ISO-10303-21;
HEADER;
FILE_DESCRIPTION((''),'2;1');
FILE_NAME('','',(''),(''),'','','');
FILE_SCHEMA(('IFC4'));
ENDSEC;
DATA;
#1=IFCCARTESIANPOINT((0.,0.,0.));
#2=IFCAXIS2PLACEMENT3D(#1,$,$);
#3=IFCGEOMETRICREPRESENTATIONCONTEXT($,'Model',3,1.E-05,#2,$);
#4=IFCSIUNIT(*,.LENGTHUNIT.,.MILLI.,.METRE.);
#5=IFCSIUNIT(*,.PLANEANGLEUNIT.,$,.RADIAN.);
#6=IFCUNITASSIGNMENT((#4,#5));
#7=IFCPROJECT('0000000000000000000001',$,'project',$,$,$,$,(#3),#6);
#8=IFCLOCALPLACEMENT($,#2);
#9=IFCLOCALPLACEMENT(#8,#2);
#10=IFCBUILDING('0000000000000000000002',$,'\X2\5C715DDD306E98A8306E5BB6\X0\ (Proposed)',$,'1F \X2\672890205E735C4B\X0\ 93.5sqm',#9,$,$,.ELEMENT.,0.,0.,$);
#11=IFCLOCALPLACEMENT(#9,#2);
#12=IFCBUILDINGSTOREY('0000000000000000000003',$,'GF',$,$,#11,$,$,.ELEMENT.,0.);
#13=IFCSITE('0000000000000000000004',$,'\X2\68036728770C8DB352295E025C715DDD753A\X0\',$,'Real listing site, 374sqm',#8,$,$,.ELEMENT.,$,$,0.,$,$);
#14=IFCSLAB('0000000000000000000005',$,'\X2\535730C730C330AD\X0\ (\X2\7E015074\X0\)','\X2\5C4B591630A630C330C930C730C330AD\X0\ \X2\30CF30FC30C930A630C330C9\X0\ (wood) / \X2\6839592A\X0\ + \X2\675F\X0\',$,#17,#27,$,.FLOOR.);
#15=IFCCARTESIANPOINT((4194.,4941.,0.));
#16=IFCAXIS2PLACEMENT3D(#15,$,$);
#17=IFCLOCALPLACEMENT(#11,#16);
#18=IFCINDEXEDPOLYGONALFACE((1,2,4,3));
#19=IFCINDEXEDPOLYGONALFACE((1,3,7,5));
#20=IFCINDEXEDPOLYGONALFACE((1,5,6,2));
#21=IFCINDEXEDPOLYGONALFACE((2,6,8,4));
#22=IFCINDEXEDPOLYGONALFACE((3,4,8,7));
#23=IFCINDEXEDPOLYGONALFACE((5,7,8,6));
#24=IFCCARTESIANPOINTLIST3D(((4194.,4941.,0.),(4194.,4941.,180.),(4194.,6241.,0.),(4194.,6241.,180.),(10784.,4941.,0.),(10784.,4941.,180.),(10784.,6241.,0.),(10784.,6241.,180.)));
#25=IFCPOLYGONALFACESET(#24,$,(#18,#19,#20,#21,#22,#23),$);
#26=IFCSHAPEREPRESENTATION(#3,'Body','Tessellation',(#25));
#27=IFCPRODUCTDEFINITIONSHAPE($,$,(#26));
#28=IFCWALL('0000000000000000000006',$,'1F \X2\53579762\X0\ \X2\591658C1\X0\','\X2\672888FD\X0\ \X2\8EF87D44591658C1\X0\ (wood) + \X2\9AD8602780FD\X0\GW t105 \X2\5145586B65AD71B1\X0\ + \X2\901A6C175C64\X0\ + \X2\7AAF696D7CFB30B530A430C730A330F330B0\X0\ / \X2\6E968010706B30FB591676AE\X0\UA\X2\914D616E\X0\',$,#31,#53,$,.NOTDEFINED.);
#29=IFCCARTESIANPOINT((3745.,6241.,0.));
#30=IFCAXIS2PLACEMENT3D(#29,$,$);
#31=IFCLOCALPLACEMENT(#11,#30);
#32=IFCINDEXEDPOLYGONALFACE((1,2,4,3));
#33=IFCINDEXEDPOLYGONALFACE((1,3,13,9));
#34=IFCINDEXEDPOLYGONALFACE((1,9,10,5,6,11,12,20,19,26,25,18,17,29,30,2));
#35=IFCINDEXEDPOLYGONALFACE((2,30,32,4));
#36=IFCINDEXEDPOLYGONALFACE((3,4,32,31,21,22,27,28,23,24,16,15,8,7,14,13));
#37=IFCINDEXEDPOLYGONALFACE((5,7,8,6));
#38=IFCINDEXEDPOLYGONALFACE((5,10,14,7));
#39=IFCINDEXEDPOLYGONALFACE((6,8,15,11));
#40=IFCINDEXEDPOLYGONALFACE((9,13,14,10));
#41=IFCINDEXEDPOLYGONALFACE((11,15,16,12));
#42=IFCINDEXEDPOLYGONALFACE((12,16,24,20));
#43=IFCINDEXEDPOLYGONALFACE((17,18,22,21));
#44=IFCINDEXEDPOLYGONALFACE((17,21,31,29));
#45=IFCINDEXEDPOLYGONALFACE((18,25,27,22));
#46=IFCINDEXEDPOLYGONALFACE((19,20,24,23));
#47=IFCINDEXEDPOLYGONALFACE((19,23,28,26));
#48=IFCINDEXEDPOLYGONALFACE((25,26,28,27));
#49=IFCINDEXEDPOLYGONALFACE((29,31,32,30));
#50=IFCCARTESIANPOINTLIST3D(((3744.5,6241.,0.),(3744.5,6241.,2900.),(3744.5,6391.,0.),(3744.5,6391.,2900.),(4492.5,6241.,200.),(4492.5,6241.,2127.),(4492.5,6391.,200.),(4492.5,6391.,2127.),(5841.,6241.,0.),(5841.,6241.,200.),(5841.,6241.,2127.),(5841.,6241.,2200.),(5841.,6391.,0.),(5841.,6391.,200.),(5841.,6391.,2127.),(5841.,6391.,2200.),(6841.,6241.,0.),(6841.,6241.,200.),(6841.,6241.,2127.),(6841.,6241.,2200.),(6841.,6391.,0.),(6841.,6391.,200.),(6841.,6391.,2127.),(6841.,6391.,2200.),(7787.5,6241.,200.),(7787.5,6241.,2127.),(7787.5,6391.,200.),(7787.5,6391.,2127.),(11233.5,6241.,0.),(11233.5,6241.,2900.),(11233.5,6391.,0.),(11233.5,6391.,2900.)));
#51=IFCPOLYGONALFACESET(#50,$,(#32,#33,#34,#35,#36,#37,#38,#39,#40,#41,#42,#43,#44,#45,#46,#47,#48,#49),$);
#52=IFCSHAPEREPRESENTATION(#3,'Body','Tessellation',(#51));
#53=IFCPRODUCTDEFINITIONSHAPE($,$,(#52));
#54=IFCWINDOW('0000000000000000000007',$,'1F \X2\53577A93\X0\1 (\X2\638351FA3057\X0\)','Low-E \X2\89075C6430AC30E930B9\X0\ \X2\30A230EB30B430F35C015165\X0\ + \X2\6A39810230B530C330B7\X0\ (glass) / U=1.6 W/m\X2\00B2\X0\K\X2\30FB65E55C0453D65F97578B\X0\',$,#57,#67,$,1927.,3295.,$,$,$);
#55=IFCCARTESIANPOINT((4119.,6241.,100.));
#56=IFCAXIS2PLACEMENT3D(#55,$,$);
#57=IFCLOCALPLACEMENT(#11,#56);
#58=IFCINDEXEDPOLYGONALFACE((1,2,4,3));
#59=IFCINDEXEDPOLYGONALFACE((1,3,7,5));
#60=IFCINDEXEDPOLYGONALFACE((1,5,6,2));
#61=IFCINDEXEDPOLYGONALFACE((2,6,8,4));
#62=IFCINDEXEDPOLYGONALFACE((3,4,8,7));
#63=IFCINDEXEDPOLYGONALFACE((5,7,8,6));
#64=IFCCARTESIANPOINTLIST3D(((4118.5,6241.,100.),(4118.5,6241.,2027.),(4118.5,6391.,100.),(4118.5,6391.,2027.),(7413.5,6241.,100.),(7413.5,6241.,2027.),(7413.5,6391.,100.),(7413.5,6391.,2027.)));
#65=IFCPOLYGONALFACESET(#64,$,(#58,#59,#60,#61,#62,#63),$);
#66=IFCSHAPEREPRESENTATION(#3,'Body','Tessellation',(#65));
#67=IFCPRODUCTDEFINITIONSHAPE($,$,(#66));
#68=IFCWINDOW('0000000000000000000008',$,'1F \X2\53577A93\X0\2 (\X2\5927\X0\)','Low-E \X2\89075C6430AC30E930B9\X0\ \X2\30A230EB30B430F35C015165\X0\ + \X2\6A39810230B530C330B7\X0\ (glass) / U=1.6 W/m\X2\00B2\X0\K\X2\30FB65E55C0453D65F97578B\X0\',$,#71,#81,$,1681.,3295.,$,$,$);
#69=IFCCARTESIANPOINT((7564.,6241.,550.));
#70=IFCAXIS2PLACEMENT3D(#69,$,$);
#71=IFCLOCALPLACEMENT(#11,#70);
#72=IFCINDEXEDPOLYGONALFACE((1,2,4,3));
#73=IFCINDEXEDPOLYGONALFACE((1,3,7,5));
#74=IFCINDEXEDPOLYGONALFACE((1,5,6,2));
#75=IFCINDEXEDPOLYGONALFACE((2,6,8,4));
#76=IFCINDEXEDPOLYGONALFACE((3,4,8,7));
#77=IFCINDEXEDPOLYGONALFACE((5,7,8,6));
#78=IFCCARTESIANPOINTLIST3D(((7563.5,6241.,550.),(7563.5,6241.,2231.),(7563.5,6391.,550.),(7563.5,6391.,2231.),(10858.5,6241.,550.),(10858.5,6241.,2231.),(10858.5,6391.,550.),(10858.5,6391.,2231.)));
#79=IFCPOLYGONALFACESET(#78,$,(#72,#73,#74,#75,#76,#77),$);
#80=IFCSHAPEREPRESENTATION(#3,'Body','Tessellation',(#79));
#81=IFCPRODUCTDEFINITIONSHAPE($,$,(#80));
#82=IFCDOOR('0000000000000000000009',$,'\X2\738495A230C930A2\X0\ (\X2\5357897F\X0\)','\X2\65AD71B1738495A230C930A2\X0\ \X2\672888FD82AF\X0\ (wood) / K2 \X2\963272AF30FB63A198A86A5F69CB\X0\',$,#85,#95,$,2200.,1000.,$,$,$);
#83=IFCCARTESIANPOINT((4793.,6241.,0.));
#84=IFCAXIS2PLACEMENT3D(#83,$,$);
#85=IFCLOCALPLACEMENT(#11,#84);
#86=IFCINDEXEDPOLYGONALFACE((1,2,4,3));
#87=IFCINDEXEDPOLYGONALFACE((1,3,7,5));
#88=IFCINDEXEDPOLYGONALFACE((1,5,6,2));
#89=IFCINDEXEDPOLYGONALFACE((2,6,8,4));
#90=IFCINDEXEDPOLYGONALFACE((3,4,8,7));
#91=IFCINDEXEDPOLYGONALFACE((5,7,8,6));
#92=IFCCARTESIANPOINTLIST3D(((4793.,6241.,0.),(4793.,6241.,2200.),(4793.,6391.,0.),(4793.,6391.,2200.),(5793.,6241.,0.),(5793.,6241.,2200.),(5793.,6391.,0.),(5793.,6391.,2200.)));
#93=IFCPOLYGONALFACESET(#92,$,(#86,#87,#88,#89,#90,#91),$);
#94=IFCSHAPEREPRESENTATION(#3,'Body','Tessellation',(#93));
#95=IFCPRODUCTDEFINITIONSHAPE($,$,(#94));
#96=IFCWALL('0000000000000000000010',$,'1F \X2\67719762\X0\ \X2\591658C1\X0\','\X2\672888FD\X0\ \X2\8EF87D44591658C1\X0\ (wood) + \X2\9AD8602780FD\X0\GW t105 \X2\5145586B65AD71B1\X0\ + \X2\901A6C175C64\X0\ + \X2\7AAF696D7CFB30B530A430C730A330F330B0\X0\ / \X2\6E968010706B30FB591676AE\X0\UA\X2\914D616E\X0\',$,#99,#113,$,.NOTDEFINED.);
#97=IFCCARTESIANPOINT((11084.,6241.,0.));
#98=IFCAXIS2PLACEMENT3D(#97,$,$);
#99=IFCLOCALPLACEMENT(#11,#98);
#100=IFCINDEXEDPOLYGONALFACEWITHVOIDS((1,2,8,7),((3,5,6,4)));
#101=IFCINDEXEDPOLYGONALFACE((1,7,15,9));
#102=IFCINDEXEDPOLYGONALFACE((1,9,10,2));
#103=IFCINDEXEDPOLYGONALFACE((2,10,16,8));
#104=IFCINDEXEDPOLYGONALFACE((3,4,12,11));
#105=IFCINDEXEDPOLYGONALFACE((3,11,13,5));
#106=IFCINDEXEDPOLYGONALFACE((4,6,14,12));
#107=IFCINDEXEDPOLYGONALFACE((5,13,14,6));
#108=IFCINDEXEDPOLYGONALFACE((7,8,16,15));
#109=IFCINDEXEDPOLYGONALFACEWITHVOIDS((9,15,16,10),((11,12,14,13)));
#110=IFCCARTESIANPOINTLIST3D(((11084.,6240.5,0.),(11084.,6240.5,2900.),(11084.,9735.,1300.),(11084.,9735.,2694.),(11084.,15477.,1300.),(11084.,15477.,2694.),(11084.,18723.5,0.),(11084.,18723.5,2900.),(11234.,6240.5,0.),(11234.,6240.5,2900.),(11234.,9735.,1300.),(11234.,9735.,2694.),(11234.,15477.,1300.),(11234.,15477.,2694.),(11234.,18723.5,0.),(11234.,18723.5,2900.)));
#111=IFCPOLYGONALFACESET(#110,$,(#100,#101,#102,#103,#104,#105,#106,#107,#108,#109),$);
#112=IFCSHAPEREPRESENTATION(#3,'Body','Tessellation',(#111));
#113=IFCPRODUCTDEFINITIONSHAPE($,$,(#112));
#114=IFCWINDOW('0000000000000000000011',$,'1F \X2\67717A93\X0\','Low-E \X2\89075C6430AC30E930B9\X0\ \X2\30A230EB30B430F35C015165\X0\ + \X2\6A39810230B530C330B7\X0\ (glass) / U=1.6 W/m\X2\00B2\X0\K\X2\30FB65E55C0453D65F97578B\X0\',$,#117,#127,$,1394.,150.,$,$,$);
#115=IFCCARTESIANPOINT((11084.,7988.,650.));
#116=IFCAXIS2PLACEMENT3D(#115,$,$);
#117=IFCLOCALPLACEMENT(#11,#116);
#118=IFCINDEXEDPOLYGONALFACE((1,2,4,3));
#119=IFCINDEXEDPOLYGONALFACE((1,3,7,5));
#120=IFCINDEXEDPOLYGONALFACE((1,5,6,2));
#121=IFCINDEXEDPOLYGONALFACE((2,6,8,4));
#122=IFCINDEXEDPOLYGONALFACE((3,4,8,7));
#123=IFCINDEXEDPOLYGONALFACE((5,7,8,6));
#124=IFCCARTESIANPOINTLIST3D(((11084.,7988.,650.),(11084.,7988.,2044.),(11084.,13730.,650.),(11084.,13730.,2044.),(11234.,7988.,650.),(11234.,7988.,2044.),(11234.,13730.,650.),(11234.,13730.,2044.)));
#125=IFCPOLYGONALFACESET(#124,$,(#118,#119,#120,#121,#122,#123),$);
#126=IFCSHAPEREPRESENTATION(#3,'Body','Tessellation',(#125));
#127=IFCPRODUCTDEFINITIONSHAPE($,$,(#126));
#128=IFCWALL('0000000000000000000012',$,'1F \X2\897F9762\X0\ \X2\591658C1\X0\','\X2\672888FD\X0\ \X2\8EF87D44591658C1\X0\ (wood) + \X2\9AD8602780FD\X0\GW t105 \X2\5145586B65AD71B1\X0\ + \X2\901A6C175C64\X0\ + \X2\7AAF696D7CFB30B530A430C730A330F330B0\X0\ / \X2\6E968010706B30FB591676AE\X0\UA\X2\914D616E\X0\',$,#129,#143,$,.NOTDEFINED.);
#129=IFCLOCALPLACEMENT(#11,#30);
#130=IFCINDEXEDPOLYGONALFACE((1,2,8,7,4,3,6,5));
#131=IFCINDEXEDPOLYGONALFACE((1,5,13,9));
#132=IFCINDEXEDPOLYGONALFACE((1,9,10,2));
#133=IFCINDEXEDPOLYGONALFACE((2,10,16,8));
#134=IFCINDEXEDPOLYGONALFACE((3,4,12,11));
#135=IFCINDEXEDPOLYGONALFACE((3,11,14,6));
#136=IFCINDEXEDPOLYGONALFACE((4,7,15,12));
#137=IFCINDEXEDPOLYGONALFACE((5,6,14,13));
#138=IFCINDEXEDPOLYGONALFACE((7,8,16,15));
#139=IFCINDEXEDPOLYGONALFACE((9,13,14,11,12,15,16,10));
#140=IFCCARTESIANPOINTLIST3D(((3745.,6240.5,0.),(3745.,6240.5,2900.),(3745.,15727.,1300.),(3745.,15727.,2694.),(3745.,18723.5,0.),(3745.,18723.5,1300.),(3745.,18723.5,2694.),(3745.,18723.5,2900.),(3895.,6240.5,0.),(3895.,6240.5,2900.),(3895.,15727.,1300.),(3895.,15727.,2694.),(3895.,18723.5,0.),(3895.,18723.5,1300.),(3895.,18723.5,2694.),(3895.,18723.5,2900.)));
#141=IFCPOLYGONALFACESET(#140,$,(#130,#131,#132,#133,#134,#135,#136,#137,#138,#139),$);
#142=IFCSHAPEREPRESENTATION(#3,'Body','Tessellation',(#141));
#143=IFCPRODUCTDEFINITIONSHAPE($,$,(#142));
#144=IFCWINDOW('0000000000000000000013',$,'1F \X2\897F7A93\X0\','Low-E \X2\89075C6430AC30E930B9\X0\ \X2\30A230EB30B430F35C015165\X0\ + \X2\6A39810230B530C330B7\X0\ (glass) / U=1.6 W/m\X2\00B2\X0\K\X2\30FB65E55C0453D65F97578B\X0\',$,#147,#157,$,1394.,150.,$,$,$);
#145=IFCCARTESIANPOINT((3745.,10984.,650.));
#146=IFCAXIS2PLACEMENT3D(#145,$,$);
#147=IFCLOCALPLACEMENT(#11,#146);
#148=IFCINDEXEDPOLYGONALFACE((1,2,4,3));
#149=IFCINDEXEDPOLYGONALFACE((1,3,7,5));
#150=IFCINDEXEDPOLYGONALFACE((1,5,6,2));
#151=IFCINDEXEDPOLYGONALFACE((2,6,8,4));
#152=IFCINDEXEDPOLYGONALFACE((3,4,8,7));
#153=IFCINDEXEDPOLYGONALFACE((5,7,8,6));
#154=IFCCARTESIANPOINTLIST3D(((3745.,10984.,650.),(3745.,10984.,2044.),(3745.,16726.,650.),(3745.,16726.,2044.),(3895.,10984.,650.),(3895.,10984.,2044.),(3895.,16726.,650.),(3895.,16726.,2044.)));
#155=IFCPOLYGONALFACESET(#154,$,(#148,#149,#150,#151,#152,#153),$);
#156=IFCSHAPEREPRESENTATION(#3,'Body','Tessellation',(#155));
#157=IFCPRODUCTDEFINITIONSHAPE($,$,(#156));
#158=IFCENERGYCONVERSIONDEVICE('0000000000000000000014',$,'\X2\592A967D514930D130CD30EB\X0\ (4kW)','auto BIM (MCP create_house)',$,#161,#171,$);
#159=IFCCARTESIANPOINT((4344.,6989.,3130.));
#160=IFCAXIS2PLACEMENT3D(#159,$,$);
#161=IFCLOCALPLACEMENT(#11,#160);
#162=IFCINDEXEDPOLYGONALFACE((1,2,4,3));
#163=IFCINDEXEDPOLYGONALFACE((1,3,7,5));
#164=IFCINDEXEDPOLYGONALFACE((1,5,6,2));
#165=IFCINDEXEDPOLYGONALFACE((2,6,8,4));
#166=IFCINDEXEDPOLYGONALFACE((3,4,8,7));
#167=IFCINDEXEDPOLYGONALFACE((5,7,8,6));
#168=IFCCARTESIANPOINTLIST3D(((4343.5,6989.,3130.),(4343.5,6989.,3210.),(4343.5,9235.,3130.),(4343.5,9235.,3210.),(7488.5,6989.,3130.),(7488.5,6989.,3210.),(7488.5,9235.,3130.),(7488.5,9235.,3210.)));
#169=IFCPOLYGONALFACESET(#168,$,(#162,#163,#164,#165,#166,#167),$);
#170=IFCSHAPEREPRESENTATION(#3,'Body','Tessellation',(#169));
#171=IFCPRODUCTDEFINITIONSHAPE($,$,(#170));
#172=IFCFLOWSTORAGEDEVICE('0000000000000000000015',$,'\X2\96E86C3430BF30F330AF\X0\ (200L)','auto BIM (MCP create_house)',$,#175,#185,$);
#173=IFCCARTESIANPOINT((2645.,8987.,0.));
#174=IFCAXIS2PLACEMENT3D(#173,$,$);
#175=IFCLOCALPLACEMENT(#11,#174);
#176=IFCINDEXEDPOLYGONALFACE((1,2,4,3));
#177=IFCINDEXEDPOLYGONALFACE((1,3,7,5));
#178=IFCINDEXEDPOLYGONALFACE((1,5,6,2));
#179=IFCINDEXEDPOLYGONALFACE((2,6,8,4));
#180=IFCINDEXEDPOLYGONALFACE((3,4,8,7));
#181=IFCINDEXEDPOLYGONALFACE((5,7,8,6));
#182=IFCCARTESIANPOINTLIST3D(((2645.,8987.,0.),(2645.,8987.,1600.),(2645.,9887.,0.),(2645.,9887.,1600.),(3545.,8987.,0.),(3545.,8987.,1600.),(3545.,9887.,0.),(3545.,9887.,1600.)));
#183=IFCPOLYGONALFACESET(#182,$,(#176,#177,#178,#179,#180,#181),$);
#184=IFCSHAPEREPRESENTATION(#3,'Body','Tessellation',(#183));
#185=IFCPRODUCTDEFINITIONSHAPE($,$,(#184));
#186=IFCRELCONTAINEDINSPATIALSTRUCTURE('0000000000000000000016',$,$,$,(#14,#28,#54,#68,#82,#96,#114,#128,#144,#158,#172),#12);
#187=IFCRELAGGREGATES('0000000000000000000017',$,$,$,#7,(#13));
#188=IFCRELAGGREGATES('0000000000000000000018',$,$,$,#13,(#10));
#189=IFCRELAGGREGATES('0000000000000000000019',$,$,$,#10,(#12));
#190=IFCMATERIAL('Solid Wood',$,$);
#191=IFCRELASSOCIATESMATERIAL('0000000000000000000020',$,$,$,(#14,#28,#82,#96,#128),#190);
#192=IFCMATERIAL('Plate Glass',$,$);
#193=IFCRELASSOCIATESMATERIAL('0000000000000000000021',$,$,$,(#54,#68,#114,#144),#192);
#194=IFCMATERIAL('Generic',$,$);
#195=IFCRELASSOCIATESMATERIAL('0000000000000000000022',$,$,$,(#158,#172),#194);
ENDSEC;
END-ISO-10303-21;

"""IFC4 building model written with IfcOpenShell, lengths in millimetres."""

from ifc_helpers import new_model, si_unit, frame, frame_2d, origin, place, context, project, spatial, rectangle, extrude, material, element, fill, save


model = new_model("IFC4")

# Units and contexts
model_context = context("Model", 3, precision=1e-05, world=origin())
ifc_project = project(units=[si_unit("LENGTHUNIT", "METRE", prefix="MILLI"), si_unit("PLANEANGLEUNIT", "RADIAN")], contexts=[model_context])

# Site, building, storey
site_placement = place(None, origin())
site = spatial("IfcSite", under=ifc_project, at=site_placement, Name="栃木県足利市山川町", ObjectType="Real listing site, 374sqm", CompositionType="ELEMENT", RefElevation=0.0)
building_placement = place(site_placement, origin())
building = spatial("IfcBuilding", under=site, at=building_placement, Name="山川の風の家 (Proposed)", ObjectType="1F 木造平屋 93.5sqm", CompositionType="ELEMENT", ElevationOfRefHeight=0.0, ElevationOfTerrain=0.0)
storey_placement = place(building_placement, origin())
storey = spatial("IfcBuildingStorey", under=building, at=storey_placement, Name="GF", CompositionType="ELEMENT", Elevation=0.0)

# Slab
ifc_material_1 = material(Name="Solid Wood")
slab_1_placement = place(storey_placement, frame((4194.0, 4941.0, 0.0)))
element("IfcSlab", 1, at=slab_1_placement, inside=storey, material=ifc_material_1, Name="南デッキ (縁側)", Description="屋外ウッドデッキ ハードウッド (wood) / 根太 + 束", PredefinedType="FLOOR", context=model_context, shape_type="SweptSolid", body=[
    extrude(rectangle(XDim=6590.0, YDim=1300.0, at=frame_2d((3295.0, 650.0))), frame((4194.0, 4941.0, 0.0)), (0.0, 0.0, 1.0), 180.0),
])

# Wall, openings, windows, door
wall_1_placement = place(storey_placement, frame((3745.0, 6241.0, 0.0)))
wall_1 = element("IfcWall", 2, at=wall_1_placement, inside=storey, material=ifc_material_1, Name="1F 南面 外壁", Description="木製 軸組外壁 (wood) + 高性能GW t105 充填断熱 + 通気層 + 窯業系サイディング / 準耐火・外皮UA配慮", PredefinedType="NOTDEFINED", context=model_context, shape_type="SweptSolid", body=[
    extrude(rectangle(XDim=7489.0, YDim=150.0, at=frame_2d((3744.0, 75.0))), frame((3745.0, 6241.0, 0.0)), (0.0, 0.0, 1.0), 2900.0),
])
opening_1_placement = place(storey_placement, frame((4119.0, 6241.0, 100.0)))
opening_1 = element("IfcOpeningElement", 3, at=opening_1_placement, cuts=wall_1, PredefinedType="NOTDEFINED", context=model_context, shape_type="SweptSolid", body=[
    extrude(rectangle(XDim=3295.0, YDim=150.0, at=frame_2d((1647.0, 75.0))), frame((4119.0, 6241.0, 100.0)), (0.0, 0.0, 1.0), 1927.0),
])
opening_2_placement = place(storey_placement, frame((7564.0, 6241.0, 550.0)))
opening_2 = element("IfcOpeningElement", 4, at=opening_2_placement, cuts=wall_1, PredefinedType="NOTDEFINED", context=model_context, shape_type="SweptSolid", body=[
    extrude(rectangle(XDim=3295.0, YDim=150.0, at=frame_2d((1647.0, 75.0))), frame((7564.0, 6241.0, 550.0)), (0.0, 0.0, 1.0), 1681.0),
])
opening_3_placement = place(storey_placement, frame((4793.0, 6241.0, 0.0)))
opening_3 = element("IfcOpeningElement", 5, at=opening_3_placement, cuts=wall_1, PredefinedType="NOTDEFINED", context=model_context, shape_type="SweptSolid", body=[
    extrude(rectangle(XDim=1000.0, YDim=150.0, at=frame_2d((500.0, 75.0))), frame((4793.0, 6241.0, 0.0)), (0.0, 0.0, 1.0), 2200.0),
])
ifc_material_2 = material(Name="Plate Glass")
window_1_placement = place(storey_placement, frame((4119.0, 6241.0, 100.0)))
window_1 = element("IfcWindow", 6, at=window_1_placement, inside=storey, material=ifc_material_2, Name="1F 南窓1 (掃出し)", Description="Low-E 複層ガラス アルゴン封入 + 樹脂サッシ (glass) / U=1.6 W/m²K・日射取得型", OverallHeight=1927.0, OverallWidth=3295.0, context=model_context, shape_type="SweptSolid", body=[
    extrude(rectangle(XDim=3295.0, YDim=150.0, at=frame_2d((1647.0, 75.0))), frame((4119.0, 6241.0, 100.0)), (0.0, 0.0, 1.0), 1927.0),
])
fill(opening_1, window_1)
window_2_placement = place(storey_placement, frame((7564.0, 6241.0, 550.0)))
window_2 = element("IfcWindow", 7, at=window_2_placement, inside=storey, material=ifc_material_2, Name="1F 南窓2 (大)", Description="Low-E 複層ガラス アルゴン封入 + 樹脂サッシ (glass) / U=1.6 W/m²K・日射取得型", OverallHeight=1681.0, OverallWidth=3295.0, context=model_context, shape_type="SweptSolid", body=[
    extrude(rectangle(XDim=3295.0, YDim=150.0, at=frame_2d((1647.0, 75.0))), frame((7564.0, 6241.0, 550.0)), (0.0, 0.0, 1.0), 1681.0),
])
fill(opening_2, window_2)
door_placement = place(storey_placement, frame((4793.0, 6241.0, 0.0)))
door = element("IfcDoor", 8, at=door_placement, inside=storey, material=ifc_material_1, Name="玄関ドア (南西)", Description="断熱玄関ドア 木製芯 (wood) / K2 防犯・採風機構", OverallHeight=2200.0, OverallWidth=1000.0, context=model_context, shape_type="SweptSolid", body=[
    extrude(rectangle(XDim=1000.0, YDim=150.0, at=frame_2d((500.0, 75.0))), frame((4793.0, 6241.0, 0.0)), (0.0, 0.0, 1.0), 2200.0),
])
fill(opening_3, door)

# Walls, openings, windows
wall_2_placement = place(storey_placement, frame((11084.0, 6241.0, 0.0)))
wall_2 = element("IfcWall", 9, at=wall_2_placement, inside=storey, material=ifc_material_1, Name="1F 東面 外壁", Description="木製 軸組外壁 (wood) + 高性能GW t105 充填断熱 + 通気層 + 窯業系サイディング / 準耐火・外皮UA配慮", PredefinedType="NOTDEFINED", context=model_context, shape_type="SweptSolid", body=[
    extrude(rectangle(XDim=150.0, YDim=12483.0, at=frame_2d((75.0, 6241.0))), frame((11084.0, 6241.0, 0.0)), (0.0, 0.0, 1.0), 2900.0),
])
opening_4_placement = place(storey_placement, frame((11084.0, 7988.0, 650.0)))
opening_4 = element("IfcOpeningElement", 10, at=opening_4_placement, cuts=wall_2, PredefinedType="NOTDEFINED", context=model_context, shape_type="SweptSolid", body=[
    extrude(rectangle(XDim=150.0, YDim=5742.0, at=frame_2d((75.0, 2871.0))), frame((11084.0, 7988.0, 650.0)), (0.0, 0.0, 1.0), 1394.0),
])
window_3_placement = place(storey_placement, frame((11084.0, 7988.0, 650.0)))
window_3 = element("IfcWindow", 11, at=window_3_placement, inside=storey, material=ifc_material_2, Name="1F 東窓", Description="Low-E 複層ガラス アルゴン封入 + 樹脂サッシ (glass) / U=1.6 W/m²K・日射取得型", OverallHeight=1394.0, OverallWidth=150.0, context=model_context, shape_type="SweptSolid", body=[
    extrude(rectangle(XDim=150.0, YDim=5742.0, at=frame_2d((75.0, 2871.0))), frame((11084.0, 7988.0, 650.0)), (0.0, 0.0, 1.0), 1394.0),
])
fill(opening_4, window_3)
wall_3_placement = place(storey_placement, frame((3745.0, 6241.0, 0.0)))
wall_3 = element("IfcWall", 12, at=wall_3_placement, inside=storey, material=ifc_material_1, Name="1F 西面 外壁", Description="木製 軸組外壁 (wood) + 高性能GW t105 充填断熱 + 通気層 + 窯業系サイディング / 準耐火・外皮UA配慮", PredefinedType="NOTDEFINED", context=model_context, shape_type="SweptSolid", body=[
    extrude(rectangle(XDim=150.0, YDim=12483.0, at=frame_2d((75.0, 6241.0))), frame((3745.0, 6241.0, 0.0)), (0.0, 0.0, 1.0), 2900.0),
])
opening_5_placement = place(storey_placement, frame((3745.0, 10984.0, 650.0)))
opening_5 = element("IfcOpeningElement", 13, at=opening_5_placement, cuts=wall_3, PredefinedType="NOTDEFINED", context=model_context, shape_type="SweptSolid", body=[
    extrude(rectangle(XDim=150.0, YDim=5742.0, at=frame_2d((75.0, 2871.0))), frame((3745.0, 10984.0, 650.0)), (0.0, 0.0, 1.0), 1394.0),
])
window_4_placement = place(storey_placement, frame((3745.0, 10984.0, 650.0)))
window_4 = element("IfcWindow", 14, at=window_4_placement, inside=storey, material=ifc_material_2, Name="1F 西窓", Description="Low-E 複層ガラス アルゴン封入 + 樹脂サッシ (glass) / U=1.6 W/m²K・日射取得型", OverallHeight=1394.0, OverallWidth=150.0, context=model_context, shape_type="SweptSolid", body=[
    extrude(rectangle(XDim=150.0, YDim=5742.0, at=frame_2d((75.0, 2871.0))), frame((3745.0, 10984.0, 650.0)), (0.0, 0.0, 1.0), 1394.0),
])
fill(opening_5, window_4)

# Shared definitions
ifc_material_3 = material(Name="Generic")

# Energy conversion device
energy_conversion_device_placement = place(storey_placement, frame((4344.0, 6989.0, 3130.0)))
element("IfcEnergyConversionDevice", 15, at=energy_conversion_device_placement, inside=storey, material=ifc_material_3, Name="太陽光パネル (4kW)", Description="auto BIM (MCP create_house)", context=model_context, shape_type="SweptSolid", body=[
    extrude(rectangle(XDim=3145.0, YDim=2246.0, at=frame_2d((1572.0, 1123.0))), frame((4344.0, 6989.0, 3130.0)), (0.0, 0.0, 1.0), 80.0),
])

# Flow storage device
flow_storage_device_placement = place(storey_placement, frame((2645.0, 8987.0, 0.0)))
element("IfcFlowStorageDevice", 16, at=flow_storage_device_placement, inside=storey, material=ifc_material_3, Name="雨水タンク (200L)", Description="auto BIM (MCP create_house)", context=model_context, shape_type="SweptSolid", body=[
    extrude(rectangle(XDim=900.0, YDim=900.0, at=frame_2d((450.0, 450.0))), frame((2645.0, 8987.0, 0.0)), (0.0, 0.0, 1.0), 1600.0),
])

save(model, "model.ifc")
